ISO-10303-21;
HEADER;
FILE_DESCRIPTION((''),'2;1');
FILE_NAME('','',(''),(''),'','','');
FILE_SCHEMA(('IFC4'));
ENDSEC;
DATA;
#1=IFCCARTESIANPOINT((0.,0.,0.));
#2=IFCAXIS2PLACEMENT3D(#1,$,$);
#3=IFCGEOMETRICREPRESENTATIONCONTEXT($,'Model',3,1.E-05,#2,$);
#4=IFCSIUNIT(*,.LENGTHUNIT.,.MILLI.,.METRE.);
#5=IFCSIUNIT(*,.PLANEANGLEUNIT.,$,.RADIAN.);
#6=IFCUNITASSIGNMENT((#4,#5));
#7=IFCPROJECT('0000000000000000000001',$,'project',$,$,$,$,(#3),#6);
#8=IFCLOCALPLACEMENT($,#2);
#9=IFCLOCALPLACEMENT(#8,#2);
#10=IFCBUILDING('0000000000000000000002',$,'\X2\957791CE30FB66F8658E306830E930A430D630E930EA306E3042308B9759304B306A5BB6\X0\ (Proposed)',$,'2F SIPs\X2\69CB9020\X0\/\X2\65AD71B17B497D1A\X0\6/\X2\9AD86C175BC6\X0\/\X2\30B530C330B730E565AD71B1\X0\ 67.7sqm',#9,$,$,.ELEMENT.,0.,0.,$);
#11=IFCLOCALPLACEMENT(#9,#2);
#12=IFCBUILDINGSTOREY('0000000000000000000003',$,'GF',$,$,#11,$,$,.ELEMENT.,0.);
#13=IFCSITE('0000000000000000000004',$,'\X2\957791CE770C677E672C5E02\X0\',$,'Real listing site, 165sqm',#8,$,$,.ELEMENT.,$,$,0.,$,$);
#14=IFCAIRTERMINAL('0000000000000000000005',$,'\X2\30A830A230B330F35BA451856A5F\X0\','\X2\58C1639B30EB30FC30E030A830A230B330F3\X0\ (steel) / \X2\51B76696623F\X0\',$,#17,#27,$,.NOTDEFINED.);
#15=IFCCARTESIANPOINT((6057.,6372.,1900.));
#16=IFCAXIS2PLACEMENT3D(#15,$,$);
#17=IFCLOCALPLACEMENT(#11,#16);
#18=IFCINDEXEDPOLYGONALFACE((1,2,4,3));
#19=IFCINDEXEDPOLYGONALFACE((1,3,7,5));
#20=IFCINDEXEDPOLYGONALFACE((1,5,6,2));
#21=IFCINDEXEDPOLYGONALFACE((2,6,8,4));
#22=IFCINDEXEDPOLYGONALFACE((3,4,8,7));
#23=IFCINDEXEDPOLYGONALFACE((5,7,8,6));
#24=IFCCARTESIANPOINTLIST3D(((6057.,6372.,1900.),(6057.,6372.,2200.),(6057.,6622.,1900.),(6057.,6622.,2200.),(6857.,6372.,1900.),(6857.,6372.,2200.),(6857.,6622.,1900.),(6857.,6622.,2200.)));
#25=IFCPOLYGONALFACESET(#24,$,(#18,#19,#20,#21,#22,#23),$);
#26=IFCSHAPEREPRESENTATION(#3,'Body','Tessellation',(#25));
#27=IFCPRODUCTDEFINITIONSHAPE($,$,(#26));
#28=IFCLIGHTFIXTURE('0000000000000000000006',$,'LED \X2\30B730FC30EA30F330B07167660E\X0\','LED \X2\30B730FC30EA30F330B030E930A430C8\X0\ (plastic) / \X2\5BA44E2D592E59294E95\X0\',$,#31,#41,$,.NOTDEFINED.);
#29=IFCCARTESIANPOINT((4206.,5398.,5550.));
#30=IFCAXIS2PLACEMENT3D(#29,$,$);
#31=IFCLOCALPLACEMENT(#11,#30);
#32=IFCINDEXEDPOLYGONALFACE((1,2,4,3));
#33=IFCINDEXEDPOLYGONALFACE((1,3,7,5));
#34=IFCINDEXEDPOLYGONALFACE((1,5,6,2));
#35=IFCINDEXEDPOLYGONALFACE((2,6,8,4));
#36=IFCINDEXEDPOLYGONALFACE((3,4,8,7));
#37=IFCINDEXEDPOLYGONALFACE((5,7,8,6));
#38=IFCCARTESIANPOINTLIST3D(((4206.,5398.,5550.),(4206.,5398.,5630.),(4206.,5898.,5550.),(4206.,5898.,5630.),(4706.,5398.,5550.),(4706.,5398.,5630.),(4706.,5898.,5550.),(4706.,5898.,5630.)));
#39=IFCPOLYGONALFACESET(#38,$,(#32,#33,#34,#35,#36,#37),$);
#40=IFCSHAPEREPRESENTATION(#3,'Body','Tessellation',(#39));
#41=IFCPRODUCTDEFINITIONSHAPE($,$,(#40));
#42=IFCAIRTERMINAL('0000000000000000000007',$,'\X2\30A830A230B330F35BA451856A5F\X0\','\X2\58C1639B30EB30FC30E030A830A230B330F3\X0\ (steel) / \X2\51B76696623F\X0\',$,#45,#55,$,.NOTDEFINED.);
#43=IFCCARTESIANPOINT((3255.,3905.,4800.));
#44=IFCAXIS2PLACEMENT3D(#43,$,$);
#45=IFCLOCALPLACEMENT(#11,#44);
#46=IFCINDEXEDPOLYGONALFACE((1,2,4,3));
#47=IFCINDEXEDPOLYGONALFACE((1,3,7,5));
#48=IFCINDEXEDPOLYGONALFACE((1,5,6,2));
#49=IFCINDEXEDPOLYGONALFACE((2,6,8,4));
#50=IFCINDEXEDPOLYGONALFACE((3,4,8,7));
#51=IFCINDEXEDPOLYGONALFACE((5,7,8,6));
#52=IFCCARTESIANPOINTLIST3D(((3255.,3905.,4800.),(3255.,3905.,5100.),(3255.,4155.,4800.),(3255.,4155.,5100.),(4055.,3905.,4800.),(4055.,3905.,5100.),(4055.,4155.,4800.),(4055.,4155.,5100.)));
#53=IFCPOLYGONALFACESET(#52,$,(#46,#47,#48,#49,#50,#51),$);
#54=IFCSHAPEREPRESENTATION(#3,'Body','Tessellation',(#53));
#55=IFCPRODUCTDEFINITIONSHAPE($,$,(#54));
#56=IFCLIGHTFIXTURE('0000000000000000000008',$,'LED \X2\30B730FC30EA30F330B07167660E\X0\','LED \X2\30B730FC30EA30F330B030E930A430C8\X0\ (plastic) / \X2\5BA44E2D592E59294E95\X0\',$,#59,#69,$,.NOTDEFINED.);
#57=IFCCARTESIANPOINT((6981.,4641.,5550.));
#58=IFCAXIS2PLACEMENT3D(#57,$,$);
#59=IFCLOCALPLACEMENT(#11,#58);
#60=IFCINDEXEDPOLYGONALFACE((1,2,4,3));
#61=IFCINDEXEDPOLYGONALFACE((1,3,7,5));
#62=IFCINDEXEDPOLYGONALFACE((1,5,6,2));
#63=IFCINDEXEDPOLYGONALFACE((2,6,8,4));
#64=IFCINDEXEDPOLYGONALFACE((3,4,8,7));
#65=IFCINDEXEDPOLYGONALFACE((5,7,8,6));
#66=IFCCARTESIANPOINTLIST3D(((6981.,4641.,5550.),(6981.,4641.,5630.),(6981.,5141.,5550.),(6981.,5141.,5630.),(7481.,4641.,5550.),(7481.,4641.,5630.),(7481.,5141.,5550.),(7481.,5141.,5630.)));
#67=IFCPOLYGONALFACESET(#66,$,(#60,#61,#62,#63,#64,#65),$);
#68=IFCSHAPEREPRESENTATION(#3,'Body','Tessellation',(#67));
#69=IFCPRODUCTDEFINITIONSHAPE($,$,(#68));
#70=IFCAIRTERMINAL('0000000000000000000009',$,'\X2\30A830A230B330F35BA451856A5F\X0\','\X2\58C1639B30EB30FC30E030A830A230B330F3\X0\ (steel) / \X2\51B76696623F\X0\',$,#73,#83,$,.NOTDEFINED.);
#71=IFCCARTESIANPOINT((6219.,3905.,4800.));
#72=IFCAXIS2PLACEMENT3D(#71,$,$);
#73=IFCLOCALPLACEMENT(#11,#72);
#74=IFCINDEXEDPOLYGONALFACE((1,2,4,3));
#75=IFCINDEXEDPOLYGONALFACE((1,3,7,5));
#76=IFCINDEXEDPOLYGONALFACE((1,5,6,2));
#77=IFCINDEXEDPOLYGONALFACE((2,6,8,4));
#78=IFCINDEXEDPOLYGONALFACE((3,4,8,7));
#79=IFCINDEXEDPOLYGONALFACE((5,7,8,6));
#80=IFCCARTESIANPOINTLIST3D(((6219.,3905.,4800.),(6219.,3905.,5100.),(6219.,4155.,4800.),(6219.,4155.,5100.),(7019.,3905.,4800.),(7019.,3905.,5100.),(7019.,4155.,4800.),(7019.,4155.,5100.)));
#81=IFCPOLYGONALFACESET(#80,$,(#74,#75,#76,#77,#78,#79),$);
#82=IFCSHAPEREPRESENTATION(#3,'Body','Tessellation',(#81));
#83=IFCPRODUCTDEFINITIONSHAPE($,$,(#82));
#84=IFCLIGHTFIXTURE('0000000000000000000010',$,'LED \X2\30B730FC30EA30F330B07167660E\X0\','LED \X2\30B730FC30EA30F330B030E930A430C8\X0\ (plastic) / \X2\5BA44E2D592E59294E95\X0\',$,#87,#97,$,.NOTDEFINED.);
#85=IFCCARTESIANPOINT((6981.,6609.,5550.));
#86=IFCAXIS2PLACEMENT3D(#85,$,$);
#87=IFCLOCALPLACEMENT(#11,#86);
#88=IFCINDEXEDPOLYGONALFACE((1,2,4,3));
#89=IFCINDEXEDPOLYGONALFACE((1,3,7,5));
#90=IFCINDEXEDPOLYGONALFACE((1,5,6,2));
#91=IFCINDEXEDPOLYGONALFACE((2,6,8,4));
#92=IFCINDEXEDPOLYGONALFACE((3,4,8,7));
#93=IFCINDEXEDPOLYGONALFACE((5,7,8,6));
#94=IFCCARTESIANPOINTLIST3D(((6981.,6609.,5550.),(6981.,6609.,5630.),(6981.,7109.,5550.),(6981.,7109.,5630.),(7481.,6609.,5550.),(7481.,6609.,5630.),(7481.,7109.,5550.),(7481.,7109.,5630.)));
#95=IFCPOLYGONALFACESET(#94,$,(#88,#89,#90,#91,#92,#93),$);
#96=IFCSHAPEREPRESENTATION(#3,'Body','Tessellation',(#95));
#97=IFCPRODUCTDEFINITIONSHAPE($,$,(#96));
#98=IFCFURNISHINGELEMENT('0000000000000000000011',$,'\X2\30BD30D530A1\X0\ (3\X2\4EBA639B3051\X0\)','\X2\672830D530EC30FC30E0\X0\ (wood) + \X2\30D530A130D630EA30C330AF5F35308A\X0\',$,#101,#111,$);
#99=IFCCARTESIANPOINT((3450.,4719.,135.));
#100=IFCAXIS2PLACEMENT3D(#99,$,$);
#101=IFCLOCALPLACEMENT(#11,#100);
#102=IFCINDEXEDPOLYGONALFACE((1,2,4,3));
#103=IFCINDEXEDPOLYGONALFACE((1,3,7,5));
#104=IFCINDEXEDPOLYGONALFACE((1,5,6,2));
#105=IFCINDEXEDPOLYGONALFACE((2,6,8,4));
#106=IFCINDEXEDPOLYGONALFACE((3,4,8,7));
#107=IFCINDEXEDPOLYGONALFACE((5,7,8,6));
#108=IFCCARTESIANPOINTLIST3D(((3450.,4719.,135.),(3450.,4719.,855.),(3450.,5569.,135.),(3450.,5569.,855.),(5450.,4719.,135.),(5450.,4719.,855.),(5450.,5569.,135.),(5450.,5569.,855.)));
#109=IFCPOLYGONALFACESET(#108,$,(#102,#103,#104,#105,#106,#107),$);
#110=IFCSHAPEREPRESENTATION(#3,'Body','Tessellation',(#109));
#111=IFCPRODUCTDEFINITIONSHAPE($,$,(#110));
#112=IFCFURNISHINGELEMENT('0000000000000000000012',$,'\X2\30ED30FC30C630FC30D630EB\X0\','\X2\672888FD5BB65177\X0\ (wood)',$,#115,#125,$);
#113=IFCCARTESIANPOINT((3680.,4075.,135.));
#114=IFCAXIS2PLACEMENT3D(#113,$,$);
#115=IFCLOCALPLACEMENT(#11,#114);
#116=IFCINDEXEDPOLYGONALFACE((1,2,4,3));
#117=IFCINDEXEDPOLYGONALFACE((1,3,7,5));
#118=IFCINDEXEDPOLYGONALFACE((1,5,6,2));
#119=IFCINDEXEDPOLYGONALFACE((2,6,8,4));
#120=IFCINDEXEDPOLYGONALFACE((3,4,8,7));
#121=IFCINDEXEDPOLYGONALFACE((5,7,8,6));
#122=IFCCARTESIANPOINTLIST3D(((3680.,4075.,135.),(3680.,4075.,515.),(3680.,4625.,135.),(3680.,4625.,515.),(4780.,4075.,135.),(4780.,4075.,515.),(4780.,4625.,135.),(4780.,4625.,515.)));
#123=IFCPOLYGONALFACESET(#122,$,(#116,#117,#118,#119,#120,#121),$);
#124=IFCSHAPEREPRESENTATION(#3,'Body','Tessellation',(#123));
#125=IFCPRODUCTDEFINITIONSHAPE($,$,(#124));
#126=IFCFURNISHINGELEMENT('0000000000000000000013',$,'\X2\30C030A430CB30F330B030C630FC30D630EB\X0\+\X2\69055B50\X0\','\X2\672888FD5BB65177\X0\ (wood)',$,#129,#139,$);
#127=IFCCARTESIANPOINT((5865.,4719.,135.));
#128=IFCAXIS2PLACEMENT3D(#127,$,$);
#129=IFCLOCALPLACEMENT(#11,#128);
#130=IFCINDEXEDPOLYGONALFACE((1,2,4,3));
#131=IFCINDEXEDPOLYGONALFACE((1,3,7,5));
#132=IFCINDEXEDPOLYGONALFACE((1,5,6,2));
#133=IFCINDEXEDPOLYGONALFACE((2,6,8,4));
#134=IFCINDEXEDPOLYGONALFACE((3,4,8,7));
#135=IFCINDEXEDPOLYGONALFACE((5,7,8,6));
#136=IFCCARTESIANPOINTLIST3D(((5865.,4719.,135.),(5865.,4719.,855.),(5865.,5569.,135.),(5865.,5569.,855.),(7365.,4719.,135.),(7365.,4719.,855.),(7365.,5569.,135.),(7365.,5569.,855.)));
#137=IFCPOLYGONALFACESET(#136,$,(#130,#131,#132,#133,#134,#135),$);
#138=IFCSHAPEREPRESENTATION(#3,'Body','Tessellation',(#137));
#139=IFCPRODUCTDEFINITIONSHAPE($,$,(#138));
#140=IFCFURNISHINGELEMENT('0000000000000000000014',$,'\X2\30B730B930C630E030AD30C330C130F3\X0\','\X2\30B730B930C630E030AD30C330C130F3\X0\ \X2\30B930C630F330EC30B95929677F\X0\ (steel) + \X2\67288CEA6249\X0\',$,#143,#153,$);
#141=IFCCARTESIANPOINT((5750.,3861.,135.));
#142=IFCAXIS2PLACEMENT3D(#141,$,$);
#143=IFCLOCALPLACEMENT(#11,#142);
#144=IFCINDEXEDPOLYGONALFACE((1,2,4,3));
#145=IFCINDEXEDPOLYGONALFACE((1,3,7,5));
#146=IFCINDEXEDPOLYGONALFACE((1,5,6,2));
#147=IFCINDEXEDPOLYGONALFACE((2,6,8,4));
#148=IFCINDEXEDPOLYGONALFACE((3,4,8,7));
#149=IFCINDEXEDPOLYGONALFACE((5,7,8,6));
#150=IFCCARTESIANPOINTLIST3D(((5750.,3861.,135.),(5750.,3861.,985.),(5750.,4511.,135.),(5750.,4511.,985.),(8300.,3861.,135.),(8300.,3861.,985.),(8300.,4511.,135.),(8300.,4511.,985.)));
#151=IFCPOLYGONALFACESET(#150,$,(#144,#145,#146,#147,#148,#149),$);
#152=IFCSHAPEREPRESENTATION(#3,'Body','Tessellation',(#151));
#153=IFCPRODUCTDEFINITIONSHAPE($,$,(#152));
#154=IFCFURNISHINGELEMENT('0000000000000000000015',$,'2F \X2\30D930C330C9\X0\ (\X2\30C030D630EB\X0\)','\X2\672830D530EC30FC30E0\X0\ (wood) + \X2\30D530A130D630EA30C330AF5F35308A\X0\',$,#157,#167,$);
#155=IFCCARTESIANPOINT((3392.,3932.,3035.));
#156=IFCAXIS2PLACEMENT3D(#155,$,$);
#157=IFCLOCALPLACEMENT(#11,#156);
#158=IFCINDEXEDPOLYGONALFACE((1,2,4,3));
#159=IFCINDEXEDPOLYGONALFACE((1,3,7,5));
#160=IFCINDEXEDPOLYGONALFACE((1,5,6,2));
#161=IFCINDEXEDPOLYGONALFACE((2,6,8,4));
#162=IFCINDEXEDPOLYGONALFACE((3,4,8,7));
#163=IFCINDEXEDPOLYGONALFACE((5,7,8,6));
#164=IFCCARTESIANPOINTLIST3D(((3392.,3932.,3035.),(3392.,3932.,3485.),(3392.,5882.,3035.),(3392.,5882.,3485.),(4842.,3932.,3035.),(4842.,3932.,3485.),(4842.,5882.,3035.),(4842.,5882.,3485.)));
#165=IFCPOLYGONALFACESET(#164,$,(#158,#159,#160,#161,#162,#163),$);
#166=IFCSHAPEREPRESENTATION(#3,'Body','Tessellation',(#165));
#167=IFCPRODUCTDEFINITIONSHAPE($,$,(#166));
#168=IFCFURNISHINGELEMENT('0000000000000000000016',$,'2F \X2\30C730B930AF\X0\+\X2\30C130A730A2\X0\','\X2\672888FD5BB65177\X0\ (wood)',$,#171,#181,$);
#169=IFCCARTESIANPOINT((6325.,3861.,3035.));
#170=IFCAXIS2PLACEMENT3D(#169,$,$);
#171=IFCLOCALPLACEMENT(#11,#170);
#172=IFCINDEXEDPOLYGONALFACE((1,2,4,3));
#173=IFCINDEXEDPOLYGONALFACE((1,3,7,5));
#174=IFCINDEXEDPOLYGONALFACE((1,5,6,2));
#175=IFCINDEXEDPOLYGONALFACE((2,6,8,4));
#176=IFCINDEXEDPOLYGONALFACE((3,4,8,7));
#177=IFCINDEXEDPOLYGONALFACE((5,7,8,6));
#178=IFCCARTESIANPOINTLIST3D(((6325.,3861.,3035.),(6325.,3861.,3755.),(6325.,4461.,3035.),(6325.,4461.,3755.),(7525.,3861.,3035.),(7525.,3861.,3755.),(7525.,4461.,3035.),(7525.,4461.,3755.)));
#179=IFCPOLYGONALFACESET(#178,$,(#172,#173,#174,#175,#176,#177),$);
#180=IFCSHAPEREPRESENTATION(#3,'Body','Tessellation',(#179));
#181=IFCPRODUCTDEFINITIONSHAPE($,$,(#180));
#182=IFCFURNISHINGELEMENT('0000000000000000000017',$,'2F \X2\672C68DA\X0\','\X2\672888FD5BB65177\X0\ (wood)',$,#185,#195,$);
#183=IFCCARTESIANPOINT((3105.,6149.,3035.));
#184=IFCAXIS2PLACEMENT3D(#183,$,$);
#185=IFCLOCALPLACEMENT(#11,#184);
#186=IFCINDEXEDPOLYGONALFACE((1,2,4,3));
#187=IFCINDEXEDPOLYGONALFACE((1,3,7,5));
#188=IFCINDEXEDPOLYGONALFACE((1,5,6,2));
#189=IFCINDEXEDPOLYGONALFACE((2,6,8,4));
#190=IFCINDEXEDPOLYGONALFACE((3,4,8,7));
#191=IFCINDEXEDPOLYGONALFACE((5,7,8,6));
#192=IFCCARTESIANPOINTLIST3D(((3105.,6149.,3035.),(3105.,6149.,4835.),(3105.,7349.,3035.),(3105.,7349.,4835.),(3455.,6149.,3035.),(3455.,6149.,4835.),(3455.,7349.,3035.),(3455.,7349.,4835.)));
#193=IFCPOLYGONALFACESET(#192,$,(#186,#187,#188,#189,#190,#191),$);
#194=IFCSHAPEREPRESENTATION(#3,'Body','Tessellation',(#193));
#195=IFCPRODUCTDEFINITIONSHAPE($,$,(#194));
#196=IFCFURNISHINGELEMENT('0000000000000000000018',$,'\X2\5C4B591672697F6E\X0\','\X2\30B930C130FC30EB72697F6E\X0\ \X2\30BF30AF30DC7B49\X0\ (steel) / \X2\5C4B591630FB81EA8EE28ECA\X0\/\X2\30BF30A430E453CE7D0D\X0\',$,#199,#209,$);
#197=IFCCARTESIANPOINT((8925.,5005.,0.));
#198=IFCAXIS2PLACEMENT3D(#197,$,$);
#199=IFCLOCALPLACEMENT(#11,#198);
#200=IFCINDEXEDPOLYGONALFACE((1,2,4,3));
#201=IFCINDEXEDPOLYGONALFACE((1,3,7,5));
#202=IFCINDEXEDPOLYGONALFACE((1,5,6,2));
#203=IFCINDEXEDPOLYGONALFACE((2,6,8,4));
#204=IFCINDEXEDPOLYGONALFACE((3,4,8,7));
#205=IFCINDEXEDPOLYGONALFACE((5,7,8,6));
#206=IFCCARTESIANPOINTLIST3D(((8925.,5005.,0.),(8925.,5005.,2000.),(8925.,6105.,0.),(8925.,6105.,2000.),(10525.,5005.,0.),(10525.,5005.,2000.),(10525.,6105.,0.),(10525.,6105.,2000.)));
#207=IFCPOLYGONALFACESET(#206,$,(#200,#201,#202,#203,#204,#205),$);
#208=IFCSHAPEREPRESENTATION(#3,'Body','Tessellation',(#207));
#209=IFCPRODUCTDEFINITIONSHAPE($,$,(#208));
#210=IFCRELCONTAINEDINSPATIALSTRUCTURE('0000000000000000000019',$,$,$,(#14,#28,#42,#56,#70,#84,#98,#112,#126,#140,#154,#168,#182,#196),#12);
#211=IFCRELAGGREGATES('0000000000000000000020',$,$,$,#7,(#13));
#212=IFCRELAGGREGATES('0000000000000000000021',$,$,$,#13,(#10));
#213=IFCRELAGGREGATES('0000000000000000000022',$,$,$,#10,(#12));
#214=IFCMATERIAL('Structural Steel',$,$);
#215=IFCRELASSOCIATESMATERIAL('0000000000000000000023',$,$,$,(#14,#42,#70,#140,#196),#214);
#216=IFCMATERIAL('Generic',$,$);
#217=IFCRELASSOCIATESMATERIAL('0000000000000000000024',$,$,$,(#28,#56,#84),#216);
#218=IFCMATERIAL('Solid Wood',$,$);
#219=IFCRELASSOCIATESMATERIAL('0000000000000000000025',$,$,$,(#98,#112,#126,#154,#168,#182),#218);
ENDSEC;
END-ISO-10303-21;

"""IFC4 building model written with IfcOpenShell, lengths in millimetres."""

from ifc_helpers import new_model, si_unit, frame, frame_2d, origin, place, context, project, spatial, rectangle, extrude, material, element, save


model = new_model("IFC4")

# Units and contexts
model_context = context("Model", 3, precision=1e-05, world=origin())
ifc_project = project(units=[si_unit("LENGTHUNIT", "METRE", prefix="MILLI"), si_unit("PLANEANGLEUNIT", "RADIAN")], contexts=[model_context])

# Site, building, storey
site_placement = place(None, origin())
site = spatial("IfcSite", under=ifc_project, at=site_placement, Name="長野県松本市", ObjectType="Real listing site, 165sqm", CompositionType="ELEMENT", RefElevation=0.0)
building_placement = place(site_placement, origin())
building = spatial("IfcBuilding", under=site, at=building_placement, Name="長野・書斎とライブラリのある静かな家 (Proposed)", ObjectType="2F SIPs構造/断熱等級6/高気密/サッシュ断熱 67.7sqm", CompositionType="ELEMENT", ElevationOfRefHeight=0.0, ElevationOfTerrain=0.0)
storey_placement = place(building_placement, origin())
storey = spatial("IfcBuildingStorey", under=building, at=storey_placement, Name="GF", CompositionType="ELEMENT", Elevation=0.0)

# Shared definitions
ifc_material_1 = material(Name="Solid Wood")

# Shared definitions
ifc_material_2 = material(Name="Structural Steel")

# Shared definitions
ifc_material_3 = material(Name="Generic")

# Air terminal
air_terminal_1_placement = place(storey_placement, frame((6057.0, 6372.0, 1900.0)))
element("IfcAirTerminal", 1, at=air_terminal_1_placement, inside=storey, material=ifc_material_2, Name="エアコン室内機", Description="壁掛ルームエアコン (steel) / 冷暖房", PredefinedType="NOTDEFINED", context=model_context, shape_type="SweptSolid", body=[
    extrude(rectangle(XDim=800.0, YDim=250.0, at=frame_2d((400.0, 125.0))), frame((6057.0, 6372.0, 1900.0)), (0.0, 0.0, 1.0), 300.0),
])

# Light fixture
light_fixture_1_placement = place(storey_placement, frame((4206.0, 5398.0, 5550.0)))
element("IfcLightFixture", 2, at=light_fixture_1_placement, inside=storey, material=ifc_material_3, Name="LED シーリング照明", Description="LED シーリングライト (plastic) / 室中央天井", PredefinedType="NOTDEFINED", context=model_context, shape_type="SweptSolid", body=[
    extrude(rectangle(XDim=500.0, YDim=500.0, at=frame_2d((250.0, 250.0))), frame((4206.0, 5398.0, 5550.0)), (0.0, 0.0, 1.0), 80.0),
])

# Air terminal
air_terminal_2_placement = place(storey_placement, frame((3255.0, 3905.0, 4800.0)))
element("IfcAirTerminal", 3, at=air_terminal_2_placement, inside=storey, material=ifc_material_2, Name="エアコン室内機", Description="壁掛ルームエアコン (steel) / 冷暖房", PredefinedType="NOTDEFINED", context=model_context, shape_type="SweptSolid", body=[
    extrude(rectangle(XDim=800.0, YDim=250.0, at=frame_2d((400.0, 125.0))), frame((3255.0, 3905.0, 4800.0)), (0.0, 0.0, 1.0), 300.0),
])

# Light fixture
light_fixture_2_placement = place(storey_placement, frame((6981.0, 4641.0, 5550.0)))
element("IfcLightFixture", 4, at=light_fixture_2_placement, inside=storey, material=ifc_material_3, Name="LED シーリング照明", Description="LED シーリングライト (plastic) / 室中央天井", PredefinedType="NOTDEFINED", context=model_context, shape_type="SweptSolid", body=[
    extrude(rectangle(XDim=500.0, YDim=500.0, at=frame_2d((250.0, 250.0))), frame((6981.0, 4641.0, 5550.0)), (0.0, 0.0, 1.0), 80.0),
])

# Air terminal
air_terminal_3_placement = place(storey_placement, frame((6219.0, 3905.0, 4800.0)))
element("IfcAirTerminal", 5, at=air_terminal_3_placement, inside=storey, material=ifc_material_2, Name="エアコン室内機", Description="壁掛ルームエアコン (steel) / 冷暖房", PredefinedType="NOTDEFINED", context=model_context, shape_type="SweptSolid", body=[
    extrude(rectangle(XDim=800.0, YDim=250.0, at=frame_2d((400.0, 125.0))), frame((6219.0, 3905.0, 4800.0)), (0.0, 0.0, 1.0), 300.0),
])

# Light fixture
light_fixture_3_placement = place(storey_placement, frame((6981.0, 6609.0, 5550.0)))
element("IfcLightFixture", 6, at=light_fixture_3_placement, inside=storey, material=ifc_material_3, Name="LED シーリング照明", Description="LED シーリングライト (plastic) / 室中央天井", PredefinedType="NOTDEFINED", context=model_context, shape_type="SweptSolid", body=[
    extrude(rectangle(XDim=500.0, YDim=500.0, at=frame_2d((250.0, 250.0))), frame((6981.0, 6609.0, 5550.0)), (0.0, 0.0, 1.0), 80.0),
])

# Furnishing elements
furnishing_1_placement = place(storey_placement, frame((3450.0, 4719.0, 135.0)))
element("IfcFurnishingElement", 7, at=furnishing_1_placement, inside=storey, material=ifc_material_1, Name="ソファ (3人掛け)", Description="木フレーム (wood) + ファブリック張り", context=model_context, shape_type="SweptSolid", body=[
    extrude(rectangle(XDim=2000.0, YDim=850.0, at=frame_2d((1000.0, 425.0))), frame((3450.0, 4719.0, 135.0)), (0.0, 0.0, 1.0), 720.0),
])
furnishing_2_placement = place(storey_placement, frame((3680.0, 4075.0, 135.0)))
element("IfcFurnishingElement", 8, at=furnishing_2_placement, inside=storey, material=ifc_material_1, Name="ローテーブル", Description="木製家具 (wood)", context=model_context, shape_type="SweptSolid", body=[
    extrude(rectangle(XDim=1100.0, YDim=550.0, at=frame_2d((550.0, 275.0))), frame((3680.0, 4075.0, 135.0)), (0.0, 0.0, 1.0), 380.0),
])
furnishing_3_placement = place(storey_placement, frame((5865.0, 4719.0, 135.0)))
element("IfcFurnishingElement", 9, at=furnishing_3_placement, inside=storey, material=ifc_material_1, Name="ダイニングテーブル+椅子", Description="木製家具 (wood)", context=model_context, shape_type="SweptSolid", body=[
    extrude(rectangle(XDim=1500.0, YDim=850.0, at=frame_2d((750.0, 425.0))), frame((5865.0, 4719.0, 135.0)), (0.0, 0.0, 1.0), 720.0),
])
furnishing_4_placement = place(storey_placement, frame((5750.0, 3861.0, 135.0)))
element("IfcFurnishingElement", 10, at=furnishing_4_placement, inside=storey, material=ifc_material_2, Name="システムキッチン", Description="システムキッチン ステンレス天板 (steel) + 木質扉", context=model_context, shape_type="SweptSolid", body=[
    extrude(rectangle(XDim=2550.0, YDim=650.0, at=frame_2d((1275.0, 325.0))), frame((5750.0, 3861.0, 135.0)), (0.0, 0.0, 1.0), 850.0),
])
furnishing_5_placement = place(storey_placement, frame((3392.0, 3932.0, 3035.0)))
element("IfcFurnishingElement", 11, at=furnishing_5_placement, inside=storey, material=ifc_material_1, Name="2F ベッド (ダブル)", Description="木フレーム (wood) + ファブリック張り", context=model_context, shape_type="SweptSolid", body=[
    extrude(rectangle(XDim=1450.0, YDim=1950.0, at=frame_2d((725.0, 975.0))), frame((3392.0, 3932.0, 3035.0)), (0.0, 0.0, 1.0), 450.0),
])
furnishing_6_placement = place(storey_placement, frame((6325.0, 3861.0, 3035.0)))
element("IfcFurnishingElement", 12, at=furnishing_6_placement, inside=storey, material=ifc_material_1, Name="2F デスク+チェア", Description="木製家具 (wood)", context=model_context, shape_type="SweptSolid", body=[
    extrude(rectangle(XDim=1200.0, YDim=600.0, at=frame_2d((600.0, 300.0))), frame((6325.0, 3861.0, 3035.0)), (0.0, 0.0, 1.0), 720.0),
])
furnishing_7_placement = place(storey_placement, frame((3105.0, 6149.0, 3035.0)))
element("IfcFurnishingElement", 13, at=furnishing_7_placement, inside=storey, material=ifc_material_1, Name="2F 本棚", Description="木製家具 (wood)", context=model_context, shape_type="SweptSolid", body=[
    extrude(rectangle(XDim=350.0, YDim=1200.0, at=frame_2d((175.0, 600.0))), frame((3105.0, 6149.0, 3035.0)), (0.0, 0.0, 1.0), 1800.0),
])
furnishing_8_placement = place(storey_placement, frame((8925.0, 5005.0, 0.0)))
element("IfcFurnishingElement", 14, at=furnishing_8_placement, inside=storey, material=ifc_material_2, Name="屋外物置", Description="スチール物置 タクボ等 (steel) / 屋外・自転車/タイヤ収納", context=model_context, shape_type="SweptSolid", body=[
    extrude(rectangle(XDim=1600.0, YDim=1100.0, at=frame_2d((800.0, 550.0))), frame((8925.0, 5005.0, 0.0)), (0.0, 0.0, 1.0), 2000.0),
])

save(model, "model.ifc")
